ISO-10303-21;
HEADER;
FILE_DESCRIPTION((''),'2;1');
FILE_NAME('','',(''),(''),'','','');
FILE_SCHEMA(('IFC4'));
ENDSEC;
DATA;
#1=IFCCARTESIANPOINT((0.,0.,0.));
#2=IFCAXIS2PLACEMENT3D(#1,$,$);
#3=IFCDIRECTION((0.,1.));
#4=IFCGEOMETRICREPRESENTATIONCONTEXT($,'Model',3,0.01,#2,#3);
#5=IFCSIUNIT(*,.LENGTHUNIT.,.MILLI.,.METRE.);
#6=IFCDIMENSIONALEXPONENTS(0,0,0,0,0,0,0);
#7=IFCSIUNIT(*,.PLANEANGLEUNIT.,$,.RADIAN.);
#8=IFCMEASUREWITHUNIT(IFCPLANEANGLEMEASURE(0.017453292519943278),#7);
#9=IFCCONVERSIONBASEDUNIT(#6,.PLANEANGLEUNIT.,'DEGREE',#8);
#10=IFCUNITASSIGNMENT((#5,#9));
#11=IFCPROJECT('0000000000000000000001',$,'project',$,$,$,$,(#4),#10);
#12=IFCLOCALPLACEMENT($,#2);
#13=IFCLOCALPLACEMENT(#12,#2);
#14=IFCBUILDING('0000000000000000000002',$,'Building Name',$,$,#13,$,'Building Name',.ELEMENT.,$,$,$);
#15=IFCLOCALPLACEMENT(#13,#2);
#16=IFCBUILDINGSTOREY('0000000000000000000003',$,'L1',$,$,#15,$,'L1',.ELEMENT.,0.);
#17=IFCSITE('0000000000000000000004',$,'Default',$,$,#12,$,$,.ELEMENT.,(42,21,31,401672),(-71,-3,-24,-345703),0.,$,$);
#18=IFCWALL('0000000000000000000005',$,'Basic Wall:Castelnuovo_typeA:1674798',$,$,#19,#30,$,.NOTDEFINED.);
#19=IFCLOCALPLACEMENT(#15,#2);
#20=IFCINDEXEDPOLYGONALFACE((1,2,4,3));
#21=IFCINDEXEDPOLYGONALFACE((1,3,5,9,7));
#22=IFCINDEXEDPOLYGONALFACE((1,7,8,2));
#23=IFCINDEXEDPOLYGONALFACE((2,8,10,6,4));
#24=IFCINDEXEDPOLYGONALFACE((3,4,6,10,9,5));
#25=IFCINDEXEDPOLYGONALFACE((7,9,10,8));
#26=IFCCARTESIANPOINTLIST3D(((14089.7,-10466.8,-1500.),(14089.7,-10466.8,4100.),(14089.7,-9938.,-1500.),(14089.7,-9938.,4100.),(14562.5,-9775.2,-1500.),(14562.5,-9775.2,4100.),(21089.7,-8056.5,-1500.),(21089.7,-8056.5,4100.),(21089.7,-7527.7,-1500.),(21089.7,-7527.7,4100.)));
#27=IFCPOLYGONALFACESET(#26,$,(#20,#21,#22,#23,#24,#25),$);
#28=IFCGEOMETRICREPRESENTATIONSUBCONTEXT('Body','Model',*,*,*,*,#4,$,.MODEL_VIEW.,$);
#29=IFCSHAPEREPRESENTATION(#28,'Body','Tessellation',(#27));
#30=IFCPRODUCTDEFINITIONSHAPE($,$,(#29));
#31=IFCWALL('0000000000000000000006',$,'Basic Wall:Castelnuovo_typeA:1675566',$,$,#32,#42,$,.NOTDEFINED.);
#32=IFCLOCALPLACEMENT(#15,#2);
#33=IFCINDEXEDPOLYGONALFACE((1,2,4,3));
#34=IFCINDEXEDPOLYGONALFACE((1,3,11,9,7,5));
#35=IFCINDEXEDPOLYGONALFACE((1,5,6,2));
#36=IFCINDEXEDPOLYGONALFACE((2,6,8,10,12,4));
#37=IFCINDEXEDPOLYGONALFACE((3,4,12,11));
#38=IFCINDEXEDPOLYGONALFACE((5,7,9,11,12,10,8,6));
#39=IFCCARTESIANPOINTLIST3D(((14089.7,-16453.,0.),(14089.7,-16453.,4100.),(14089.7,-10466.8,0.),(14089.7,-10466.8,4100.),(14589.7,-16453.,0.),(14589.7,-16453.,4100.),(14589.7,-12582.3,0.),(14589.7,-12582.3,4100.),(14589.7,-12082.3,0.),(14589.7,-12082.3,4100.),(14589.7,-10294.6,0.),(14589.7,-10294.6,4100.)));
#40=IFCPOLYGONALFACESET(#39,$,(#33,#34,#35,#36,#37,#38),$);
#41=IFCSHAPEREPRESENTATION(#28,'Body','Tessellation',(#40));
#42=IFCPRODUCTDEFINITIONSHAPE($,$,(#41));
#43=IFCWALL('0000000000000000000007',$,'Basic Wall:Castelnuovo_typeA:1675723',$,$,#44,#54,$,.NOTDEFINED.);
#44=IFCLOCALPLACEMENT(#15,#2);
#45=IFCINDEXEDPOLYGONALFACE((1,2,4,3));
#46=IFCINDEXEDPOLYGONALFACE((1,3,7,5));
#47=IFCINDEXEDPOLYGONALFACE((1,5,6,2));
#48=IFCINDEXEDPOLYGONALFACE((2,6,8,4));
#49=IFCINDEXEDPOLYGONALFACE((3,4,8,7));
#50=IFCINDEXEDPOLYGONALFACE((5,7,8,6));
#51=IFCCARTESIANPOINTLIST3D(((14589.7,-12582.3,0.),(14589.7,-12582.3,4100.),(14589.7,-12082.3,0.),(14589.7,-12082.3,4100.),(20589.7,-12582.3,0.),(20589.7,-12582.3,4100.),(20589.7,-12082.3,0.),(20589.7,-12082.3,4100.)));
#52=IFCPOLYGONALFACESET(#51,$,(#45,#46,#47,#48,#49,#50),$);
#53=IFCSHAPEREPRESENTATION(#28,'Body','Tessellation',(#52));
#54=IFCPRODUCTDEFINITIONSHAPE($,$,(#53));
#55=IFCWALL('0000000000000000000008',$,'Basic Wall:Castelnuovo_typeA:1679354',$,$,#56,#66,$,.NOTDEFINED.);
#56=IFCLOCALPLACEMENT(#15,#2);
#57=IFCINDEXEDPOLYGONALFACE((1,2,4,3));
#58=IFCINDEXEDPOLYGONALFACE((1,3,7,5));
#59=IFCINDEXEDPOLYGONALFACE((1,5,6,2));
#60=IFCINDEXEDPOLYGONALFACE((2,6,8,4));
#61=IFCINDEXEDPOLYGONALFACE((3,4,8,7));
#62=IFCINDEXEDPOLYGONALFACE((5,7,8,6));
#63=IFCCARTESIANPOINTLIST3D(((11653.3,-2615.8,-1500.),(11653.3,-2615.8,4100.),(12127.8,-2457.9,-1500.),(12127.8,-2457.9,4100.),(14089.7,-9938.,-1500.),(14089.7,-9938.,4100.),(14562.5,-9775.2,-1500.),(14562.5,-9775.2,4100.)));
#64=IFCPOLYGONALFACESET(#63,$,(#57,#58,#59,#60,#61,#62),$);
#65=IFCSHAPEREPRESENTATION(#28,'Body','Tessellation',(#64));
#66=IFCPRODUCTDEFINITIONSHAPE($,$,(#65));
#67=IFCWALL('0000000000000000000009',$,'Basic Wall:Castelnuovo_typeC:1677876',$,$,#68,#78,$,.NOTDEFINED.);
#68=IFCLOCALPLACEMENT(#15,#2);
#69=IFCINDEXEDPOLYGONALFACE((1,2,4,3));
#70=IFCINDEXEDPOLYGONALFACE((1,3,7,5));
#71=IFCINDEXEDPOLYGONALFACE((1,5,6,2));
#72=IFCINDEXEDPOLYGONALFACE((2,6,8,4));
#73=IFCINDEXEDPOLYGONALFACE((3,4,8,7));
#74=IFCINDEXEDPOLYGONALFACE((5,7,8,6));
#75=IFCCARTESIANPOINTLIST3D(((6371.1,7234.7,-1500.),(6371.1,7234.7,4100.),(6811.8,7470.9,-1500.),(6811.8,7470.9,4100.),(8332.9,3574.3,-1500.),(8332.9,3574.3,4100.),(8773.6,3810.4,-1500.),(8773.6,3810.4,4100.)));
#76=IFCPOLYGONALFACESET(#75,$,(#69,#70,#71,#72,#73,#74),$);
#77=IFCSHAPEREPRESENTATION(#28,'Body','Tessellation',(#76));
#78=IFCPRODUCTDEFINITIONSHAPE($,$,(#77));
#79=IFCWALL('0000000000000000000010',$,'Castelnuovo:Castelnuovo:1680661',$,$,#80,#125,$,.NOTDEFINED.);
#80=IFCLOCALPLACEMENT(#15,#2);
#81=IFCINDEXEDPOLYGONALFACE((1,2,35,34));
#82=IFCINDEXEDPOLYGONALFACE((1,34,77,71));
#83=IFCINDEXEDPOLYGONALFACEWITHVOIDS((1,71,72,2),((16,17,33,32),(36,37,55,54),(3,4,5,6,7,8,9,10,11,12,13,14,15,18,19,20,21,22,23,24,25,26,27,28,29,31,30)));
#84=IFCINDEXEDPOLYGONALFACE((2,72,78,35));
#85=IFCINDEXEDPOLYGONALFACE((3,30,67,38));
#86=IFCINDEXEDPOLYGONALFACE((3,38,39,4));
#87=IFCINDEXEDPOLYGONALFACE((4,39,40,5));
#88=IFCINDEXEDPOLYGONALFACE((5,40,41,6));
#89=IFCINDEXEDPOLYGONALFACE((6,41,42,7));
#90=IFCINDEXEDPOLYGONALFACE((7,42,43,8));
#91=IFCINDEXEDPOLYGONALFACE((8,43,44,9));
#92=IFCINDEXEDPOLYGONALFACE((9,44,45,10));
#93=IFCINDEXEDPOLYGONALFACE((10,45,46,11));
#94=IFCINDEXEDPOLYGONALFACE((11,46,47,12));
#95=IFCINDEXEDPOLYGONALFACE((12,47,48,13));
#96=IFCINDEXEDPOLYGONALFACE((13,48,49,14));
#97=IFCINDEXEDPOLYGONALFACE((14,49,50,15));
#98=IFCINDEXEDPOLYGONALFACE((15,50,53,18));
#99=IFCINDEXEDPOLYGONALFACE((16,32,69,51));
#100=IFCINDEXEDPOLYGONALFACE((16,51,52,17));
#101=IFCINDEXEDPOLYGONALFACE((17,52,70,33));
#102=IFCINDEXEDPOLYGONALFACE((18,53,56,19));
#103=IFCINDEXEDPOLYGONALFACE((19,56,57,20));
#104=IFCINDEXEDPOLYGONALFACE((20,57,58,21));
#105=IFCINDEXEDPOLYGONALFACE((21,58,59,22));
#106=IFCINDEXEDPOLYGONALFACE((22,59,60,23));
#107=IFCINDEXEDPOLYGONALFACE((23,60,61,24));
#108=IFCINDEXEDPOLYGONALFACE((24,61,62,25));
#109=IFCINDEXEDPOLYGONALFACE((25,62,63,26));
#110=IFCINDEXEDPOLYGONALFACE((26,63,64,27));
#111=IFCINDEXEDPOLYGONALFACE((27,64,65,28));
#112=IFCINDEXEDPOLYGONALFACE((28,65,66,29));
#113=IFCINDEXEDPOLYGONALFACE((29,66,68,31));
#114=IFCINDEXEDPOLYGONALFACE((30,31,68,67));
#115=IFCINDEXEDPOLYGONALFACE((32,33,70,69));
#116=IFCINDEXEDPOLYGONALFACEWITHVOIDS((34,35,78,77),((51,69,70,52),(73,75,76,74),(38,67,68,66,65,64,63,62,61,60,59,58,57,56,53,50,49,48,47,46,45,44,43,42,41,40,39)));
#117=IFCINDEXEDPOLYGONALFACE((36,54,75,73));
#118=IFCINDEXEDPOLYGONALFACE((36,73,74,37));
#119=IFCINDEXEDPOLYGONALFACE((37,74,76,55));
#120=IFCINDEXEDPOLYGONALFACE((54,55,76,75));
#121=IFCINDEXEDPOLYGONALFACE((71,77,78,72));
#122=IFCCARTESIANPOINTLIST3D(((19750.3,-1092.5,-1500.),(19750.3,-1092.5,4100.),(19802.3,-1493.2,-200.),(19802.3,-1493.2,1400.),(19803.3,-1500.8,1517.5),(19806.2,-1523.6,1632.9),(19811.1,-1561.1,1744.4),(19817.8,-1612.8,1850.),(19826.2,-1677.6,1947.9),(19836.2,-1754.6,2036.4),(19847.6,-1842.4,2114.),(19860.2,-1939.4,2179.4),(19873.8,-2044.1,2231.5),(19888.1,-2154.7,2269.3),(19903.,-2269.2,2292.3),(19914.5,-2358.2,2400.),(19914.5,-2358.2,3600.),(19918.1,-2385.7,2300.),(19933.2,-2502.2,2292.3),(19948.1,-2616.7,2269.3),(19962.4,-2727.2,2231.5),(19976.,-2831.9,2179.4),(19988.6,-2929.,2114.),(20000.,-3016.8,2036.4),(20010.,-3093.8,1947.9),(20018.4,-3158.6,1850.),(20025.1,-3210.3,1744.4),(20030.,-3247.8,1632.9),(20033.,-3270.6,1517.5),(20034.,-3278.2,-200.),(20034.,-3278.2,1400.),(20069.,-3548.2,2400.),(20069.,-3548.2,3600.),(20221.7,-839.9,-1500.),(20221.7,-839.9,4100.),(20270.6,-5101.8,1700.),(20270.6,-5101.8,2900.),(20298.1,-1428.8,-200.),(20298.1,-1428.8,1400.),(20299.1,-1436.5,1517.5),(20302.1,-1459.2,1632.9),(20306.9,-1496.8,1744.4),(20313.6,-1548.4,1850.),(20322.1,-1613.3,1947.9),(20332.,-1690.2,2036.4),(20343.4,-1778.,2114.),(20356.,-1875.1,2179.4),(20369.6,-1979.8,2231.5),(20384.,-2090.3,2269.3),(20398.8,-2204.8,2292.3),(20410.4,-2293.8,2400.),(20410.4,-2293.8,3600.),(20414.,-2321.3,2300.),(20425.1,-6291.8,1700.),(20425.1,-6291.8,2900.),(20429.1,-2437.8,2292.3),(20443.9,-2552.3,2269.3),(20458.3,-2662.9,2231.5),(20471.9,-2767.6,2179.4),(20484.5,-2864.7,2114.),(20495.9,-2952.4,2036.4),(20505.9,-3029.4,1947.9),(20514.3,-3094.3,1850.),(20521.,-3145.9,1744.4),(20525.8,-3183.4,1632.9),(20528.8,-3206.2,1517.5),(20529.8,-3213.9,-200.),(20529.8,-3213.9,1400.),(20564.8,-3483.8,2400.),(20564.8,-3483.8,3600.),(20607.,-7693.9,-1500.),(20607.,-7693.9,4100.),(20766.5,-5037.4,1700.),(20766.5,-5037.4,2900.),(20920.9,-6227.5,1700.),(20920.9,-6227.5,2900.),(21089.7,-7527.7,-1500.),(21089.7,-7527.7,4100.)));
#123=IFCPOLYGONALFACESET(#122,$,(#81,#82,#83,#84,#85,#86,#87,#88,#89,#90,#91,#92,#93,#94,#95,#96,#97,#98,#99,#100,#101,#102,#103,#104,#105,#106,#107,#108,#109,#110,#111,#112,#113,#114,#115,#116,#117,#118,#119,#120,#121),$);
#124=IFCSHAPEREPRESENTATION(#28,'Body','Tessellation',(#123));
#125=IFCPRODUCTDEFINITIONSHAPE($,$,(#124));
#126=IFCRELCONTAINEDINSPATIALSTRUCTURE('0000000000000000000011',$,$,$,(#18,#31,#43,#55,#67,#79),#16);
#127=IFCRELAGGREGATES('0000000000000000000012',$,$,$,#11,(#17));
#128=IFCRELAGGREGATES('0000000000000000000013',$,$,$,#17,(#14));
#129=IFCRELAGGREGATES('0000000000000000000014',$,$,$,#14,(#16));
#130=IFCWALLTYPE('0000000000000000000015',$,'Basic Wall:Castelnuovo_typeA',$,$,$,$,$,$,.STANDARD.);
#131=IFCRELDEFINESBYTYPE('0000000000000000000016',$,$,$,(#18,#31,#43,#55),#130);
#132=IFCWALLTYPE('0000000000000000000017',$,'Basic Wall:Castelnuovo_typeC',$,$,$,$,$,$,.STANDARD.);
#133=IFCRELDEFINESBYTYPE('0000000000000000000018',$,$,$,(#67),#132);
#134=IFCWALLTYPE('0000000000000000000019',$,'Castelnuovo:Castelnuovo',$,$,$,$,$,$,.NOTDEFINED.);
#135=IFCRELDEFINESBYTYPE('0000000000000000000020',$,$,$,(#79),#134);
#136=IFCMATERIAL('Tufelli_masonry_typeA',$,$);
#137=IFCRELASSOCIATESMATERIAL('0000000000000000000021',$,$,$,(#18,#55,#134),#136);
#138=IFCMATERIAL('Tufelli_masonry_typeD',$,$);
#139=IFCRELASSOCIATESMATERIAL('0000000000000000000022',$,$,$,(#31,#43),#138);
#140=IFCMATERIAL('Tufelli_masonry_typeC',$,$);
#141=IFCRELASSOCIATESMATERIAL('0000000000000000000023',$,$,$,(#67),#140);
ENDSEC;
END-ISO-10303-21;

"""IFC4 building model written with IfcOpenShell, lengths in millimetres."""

from ifc_helpers import new_model, entity, si_unit, converted_unit, direction, frame, origin, place, context, subcontext, project, spatial, line, arc, indexed_curve, outline, extrude, material, type_object, element, save


model = new_model("IFC4")

# Units and contexts
model_context = context("Model", 3, precision=0.01, world=origin(), true_north=direction((0.0, 1.0)))
body_context = subcontext(model_context, "Body", "Model", "MODEL_VIEW")
ifc_project = project(units=[si_unit("LENGTHUNIT", "METRE", prefix="MILLI"), converted_unit("PLANEANGLEUNIT", "DEGREE", entity("IfcPlaneAngleMeasure", 0.017453292519943278), si_unit("PLANEANGLEUNIT", "RADIAN"), dimensions=[0, 0, 0, 0, 0, 0, 0])], contexts=[model_context])

# Site, building, storey
site_placement = place(None, origin())
site = spatial("IfcSite", under=ifc_project, at=site_placement, Name="Default", CompositionType="ELEMENT", RefLatitude=(42, 21, 31, 401672), RefLongitude=(-71, -3, -24, -345703), RefElevation=0.0)
building_placement = place(site_placement, origin())
building = spatial("IfcBuilding", under=site, at=building_placement, Name="Building Name", LongName="Building Name", CompositionType="ELEMENT")
storey_placement = place(building_placement, origin())
storey = spatial("IfcBuildingStorey", under=building, at=storey_placement, Name="L1", LongName="L1", CompositionType="ELEMENT", Elevation=0.0)

# Walls
ifc_material_1 = material(Name="Tufelli_masonry_typeA")
wall_type_1 = type_object("IfcWallType", Name="Basic Wall:Castelnuovo_typeA", PredefinedType="STANDARD")
wall_1_placement = place(storey_placement, frame((14008.3, -10230.4, -1500.0), z_axis=(0.0, 0.0, 1.0), x_axis=(0.945519, 0.325568, 0.0)))
element("IfcWall", 1, at=wall_1_placement, inside=storey, type_object=wall_type_1, material=ifc_material_1, Name="Basic Wall:Castelnuovo_typeA:1674798", PredefinedType="NOTDEFINED", context=body_context, shape_type="SweptSolid", body=[
    extrude(outline(indexed_curve([(7403.3, -250.0), (7575.5, 250.0), (672.2, 250.0), (172.2, 250.0), (0.0, -250.0), (7403.3, -250.0)], self_intersect=False)), origin(), (0.0, 0.0, 1.0), 5600.0),
])
ifc_material_2 = material(Name="Tufelli_masonry_typeD")
wall_2_placement = place(storey_placement, frame((14339.7, -16453.0, 0.0), z_axis=(0.0, 0.0, 1.0), x_axis=(0.0, 1.0, 0.0)))
element("IfcWall", 2, at=wall_2_placement, inside=storey, type_object=wall_type_1, material=ifc_material_2, Name="Basic Wall:Castelnuovo_typeA:1675566", PredefinedType="NOTDEFINED", context=body_context, shape_type="SweptSolid", body=[
    extrude(outline(indexed_curve([(6158.4, -250.0), (5986.3, 250.0), (0.0, 250.0), (0.0, -250.0), (3870.7, -250.0), (4370.7, -250.0), (6158.4, -250.0)], self_intersect=False)), origin(), (0.0, 0.0, 1.0), 4100.0),
])
wall_3_placement = place(storey_placement, frame((14589.7, -12332.3, 0.0)))
element("IfcWall", 3, at=wall_3_placement, inside=storey, type_object=wall_type_1, material=ifc_material_2, Name="Basic Wall:Castelnuovo_typeA:1675723", PredefinedType="NOTDEFINED", context=body_context, shape_type="SweptSolid", body=[
    extrude(outline(indexed_curve([(6000.0, 250.0), (0.0, 250.0), (0.0, -250.0), (6000.0, -250.0), (6000.0, 250.0)], self_intersect=False)), origin(), (0.0, 0.0, 1.0), 4100.0),
])
wall_4_placement = place(storey_placement, frame((11890.5, -2536.8, -1500.0), z_axis=(0.0, 0.0, 1.0), x_axis=(0.315716, -0.948854, 0.0)))
element("IfcWall", 4, at=wall_4_placement, inside=storey, type_object=wall_type_1, material=ifc_material_1, Name="Basic Wall:Castelnuovo_typeA:1679354", PredefinedType="NOTDEFINED", context=body_context, shape_type="SweptSolid", body=[
    extrude(outline(indexed_curve([(7716.9, -250.0), (7711.7, 250.0), (0.0, 250.0), (0.0, -250.0), (7716.9, -250.0)], self_intersect=False)), origin(), (0.0, 0.0, 1.0), 5600.0),
])
ifc_material_3 = material(Name="Tufelli_masonry_typeC")
wall_type_2 = type_object("IfcWallType", Name="Basic Wall:Castelnuovo_typeC", PredefinedType="STANDARD")
wall_5_placement = place(storey_placement, frame((8553.2, 3692.4, -1500.0), z_axis=(0.0, 0.0, 1.0), x_axis=(-0.472369, 0.881401, 0.0)))
element("IfcWall", 5, at=wall_5_placement, inside=storey, type_object=wall_type_2, material=ifc_material_3, Name="Basic Wall:Castelnuovo_typeC:1677876", PredefinedType="NOTDEFINED", context=body_context, shape_type="SweptSolid", body=[
    extrude(outline(indexed_curve([(4153.0, 250.0), (0.0, 250.0), (0.0, -250.0), (4153.0, -250.0), (4153.0, 250.0)], self_intersect=False)), origin(), (0.0, 0.0, 1.0), 5600.0),
])

# Wall, openings
wall_type_3 = type_object("IfcWallType", Name="Castelnuovo:Castelnuovo", PredefinedType="NOTDEFINED", material=ifc_material_1)
wall_6_placement = place(storey_placement, frame((19750.3, -7693.9, -1500.0), z_axis=(0.0, 0.0, 1.0), x_axis=(0.0, 1.0, 0.0)))
wall_6 = element("IfcWall", 6, at=wall_6_placement, inside=storey, type_object=wall_type_3, Name="Castelnuovo:Castelnuovo:1680661", PredefinedType="NOTDEFINED", context=body_context, shape_type="SweptSolid", body=[
    extrude(outline(indexed_curve([(-929.1, -3281.7), (-418.7, -3281.7), (937.9, 3324.4), (409.9, 3239.0), (-929.1, -3281.7)], self_intersect=False)), frame((3405.4, -666.9, 0.0), z_axis=(0.0, 0.0, 1.0), x_axis=(0.325568, -0.945519, 0.0)), (0.0, 0.0, 1.0), 5600.0),
])
opening_1_placement = place(wall_6_placement, origin())
element("IfcOpeningElement", 7, at=opening_1_placement, cuts=wall_6, PredefinedType="OPENING", context=body_context, shape_type="SweptSolid", body=[
    extrude(outline(indexed_curve([(-600.0, -600.0), (600.0, -600.0), (600.0, 600.0), (-600.0, 600.0), (-600.0, -600.0)], self_intersect=False)), frame((1994.5, -577.7, 3800.0), z_axis=(0.128709, -0.991682, 0.0), x_axis=(0.0, 0.0, 1.0)), (0.0, 0.0, 1.0), 590.0),
])
opening_2_placement = place(wall_6_placement, origin())
element("IfcOpeningElement", 8, at=opening_2_placement, cuts=wall_6, PredefinedType="OPENING", context=body_context, shape_type="SweptSolid", body=[
    extrude(outline(indexed_curve([(-600.0, -600.0), (600.0, -600.0), (600.0, 600.0), (-600.0, 600.0), (-600.0, -600.0)], self_intersect=False)), frame((4738.1, -221.7, 4500.0), z_axis=(0.128709, -0.991682, 0.0), x_axis=(0.0, 0.0, 1.0)), (0.0, 0.0, 1.0), 590.0),
])
opening_3_placement = place(wall_6_placement, origin())
element("IfcOpeningElement", 9, at=opening_3_placement, cuts=wall_6, PredefinedType="OPENING", context=body_context, shape_type="SweptSolid", body=[
    extrude(outline(indexed_curve([(-800.0, -900.0), (800.0, -900.0), (800.0, 900.0), (-800.0, 900.0), (-1700.0, 0.0)], segments=[line(1, 2, 3, 4), arc(4, 5, 1)], self_intersect=False)), frame((5375.1, -683.5, 2100.0), z_axis=(-0.128709, 0.991682, 0.0), x_axis=(0.0, 0.0, -1.0)), (0.0, 0.0, 1.0), 1590.0),
])

save(model, "model.ifc")
